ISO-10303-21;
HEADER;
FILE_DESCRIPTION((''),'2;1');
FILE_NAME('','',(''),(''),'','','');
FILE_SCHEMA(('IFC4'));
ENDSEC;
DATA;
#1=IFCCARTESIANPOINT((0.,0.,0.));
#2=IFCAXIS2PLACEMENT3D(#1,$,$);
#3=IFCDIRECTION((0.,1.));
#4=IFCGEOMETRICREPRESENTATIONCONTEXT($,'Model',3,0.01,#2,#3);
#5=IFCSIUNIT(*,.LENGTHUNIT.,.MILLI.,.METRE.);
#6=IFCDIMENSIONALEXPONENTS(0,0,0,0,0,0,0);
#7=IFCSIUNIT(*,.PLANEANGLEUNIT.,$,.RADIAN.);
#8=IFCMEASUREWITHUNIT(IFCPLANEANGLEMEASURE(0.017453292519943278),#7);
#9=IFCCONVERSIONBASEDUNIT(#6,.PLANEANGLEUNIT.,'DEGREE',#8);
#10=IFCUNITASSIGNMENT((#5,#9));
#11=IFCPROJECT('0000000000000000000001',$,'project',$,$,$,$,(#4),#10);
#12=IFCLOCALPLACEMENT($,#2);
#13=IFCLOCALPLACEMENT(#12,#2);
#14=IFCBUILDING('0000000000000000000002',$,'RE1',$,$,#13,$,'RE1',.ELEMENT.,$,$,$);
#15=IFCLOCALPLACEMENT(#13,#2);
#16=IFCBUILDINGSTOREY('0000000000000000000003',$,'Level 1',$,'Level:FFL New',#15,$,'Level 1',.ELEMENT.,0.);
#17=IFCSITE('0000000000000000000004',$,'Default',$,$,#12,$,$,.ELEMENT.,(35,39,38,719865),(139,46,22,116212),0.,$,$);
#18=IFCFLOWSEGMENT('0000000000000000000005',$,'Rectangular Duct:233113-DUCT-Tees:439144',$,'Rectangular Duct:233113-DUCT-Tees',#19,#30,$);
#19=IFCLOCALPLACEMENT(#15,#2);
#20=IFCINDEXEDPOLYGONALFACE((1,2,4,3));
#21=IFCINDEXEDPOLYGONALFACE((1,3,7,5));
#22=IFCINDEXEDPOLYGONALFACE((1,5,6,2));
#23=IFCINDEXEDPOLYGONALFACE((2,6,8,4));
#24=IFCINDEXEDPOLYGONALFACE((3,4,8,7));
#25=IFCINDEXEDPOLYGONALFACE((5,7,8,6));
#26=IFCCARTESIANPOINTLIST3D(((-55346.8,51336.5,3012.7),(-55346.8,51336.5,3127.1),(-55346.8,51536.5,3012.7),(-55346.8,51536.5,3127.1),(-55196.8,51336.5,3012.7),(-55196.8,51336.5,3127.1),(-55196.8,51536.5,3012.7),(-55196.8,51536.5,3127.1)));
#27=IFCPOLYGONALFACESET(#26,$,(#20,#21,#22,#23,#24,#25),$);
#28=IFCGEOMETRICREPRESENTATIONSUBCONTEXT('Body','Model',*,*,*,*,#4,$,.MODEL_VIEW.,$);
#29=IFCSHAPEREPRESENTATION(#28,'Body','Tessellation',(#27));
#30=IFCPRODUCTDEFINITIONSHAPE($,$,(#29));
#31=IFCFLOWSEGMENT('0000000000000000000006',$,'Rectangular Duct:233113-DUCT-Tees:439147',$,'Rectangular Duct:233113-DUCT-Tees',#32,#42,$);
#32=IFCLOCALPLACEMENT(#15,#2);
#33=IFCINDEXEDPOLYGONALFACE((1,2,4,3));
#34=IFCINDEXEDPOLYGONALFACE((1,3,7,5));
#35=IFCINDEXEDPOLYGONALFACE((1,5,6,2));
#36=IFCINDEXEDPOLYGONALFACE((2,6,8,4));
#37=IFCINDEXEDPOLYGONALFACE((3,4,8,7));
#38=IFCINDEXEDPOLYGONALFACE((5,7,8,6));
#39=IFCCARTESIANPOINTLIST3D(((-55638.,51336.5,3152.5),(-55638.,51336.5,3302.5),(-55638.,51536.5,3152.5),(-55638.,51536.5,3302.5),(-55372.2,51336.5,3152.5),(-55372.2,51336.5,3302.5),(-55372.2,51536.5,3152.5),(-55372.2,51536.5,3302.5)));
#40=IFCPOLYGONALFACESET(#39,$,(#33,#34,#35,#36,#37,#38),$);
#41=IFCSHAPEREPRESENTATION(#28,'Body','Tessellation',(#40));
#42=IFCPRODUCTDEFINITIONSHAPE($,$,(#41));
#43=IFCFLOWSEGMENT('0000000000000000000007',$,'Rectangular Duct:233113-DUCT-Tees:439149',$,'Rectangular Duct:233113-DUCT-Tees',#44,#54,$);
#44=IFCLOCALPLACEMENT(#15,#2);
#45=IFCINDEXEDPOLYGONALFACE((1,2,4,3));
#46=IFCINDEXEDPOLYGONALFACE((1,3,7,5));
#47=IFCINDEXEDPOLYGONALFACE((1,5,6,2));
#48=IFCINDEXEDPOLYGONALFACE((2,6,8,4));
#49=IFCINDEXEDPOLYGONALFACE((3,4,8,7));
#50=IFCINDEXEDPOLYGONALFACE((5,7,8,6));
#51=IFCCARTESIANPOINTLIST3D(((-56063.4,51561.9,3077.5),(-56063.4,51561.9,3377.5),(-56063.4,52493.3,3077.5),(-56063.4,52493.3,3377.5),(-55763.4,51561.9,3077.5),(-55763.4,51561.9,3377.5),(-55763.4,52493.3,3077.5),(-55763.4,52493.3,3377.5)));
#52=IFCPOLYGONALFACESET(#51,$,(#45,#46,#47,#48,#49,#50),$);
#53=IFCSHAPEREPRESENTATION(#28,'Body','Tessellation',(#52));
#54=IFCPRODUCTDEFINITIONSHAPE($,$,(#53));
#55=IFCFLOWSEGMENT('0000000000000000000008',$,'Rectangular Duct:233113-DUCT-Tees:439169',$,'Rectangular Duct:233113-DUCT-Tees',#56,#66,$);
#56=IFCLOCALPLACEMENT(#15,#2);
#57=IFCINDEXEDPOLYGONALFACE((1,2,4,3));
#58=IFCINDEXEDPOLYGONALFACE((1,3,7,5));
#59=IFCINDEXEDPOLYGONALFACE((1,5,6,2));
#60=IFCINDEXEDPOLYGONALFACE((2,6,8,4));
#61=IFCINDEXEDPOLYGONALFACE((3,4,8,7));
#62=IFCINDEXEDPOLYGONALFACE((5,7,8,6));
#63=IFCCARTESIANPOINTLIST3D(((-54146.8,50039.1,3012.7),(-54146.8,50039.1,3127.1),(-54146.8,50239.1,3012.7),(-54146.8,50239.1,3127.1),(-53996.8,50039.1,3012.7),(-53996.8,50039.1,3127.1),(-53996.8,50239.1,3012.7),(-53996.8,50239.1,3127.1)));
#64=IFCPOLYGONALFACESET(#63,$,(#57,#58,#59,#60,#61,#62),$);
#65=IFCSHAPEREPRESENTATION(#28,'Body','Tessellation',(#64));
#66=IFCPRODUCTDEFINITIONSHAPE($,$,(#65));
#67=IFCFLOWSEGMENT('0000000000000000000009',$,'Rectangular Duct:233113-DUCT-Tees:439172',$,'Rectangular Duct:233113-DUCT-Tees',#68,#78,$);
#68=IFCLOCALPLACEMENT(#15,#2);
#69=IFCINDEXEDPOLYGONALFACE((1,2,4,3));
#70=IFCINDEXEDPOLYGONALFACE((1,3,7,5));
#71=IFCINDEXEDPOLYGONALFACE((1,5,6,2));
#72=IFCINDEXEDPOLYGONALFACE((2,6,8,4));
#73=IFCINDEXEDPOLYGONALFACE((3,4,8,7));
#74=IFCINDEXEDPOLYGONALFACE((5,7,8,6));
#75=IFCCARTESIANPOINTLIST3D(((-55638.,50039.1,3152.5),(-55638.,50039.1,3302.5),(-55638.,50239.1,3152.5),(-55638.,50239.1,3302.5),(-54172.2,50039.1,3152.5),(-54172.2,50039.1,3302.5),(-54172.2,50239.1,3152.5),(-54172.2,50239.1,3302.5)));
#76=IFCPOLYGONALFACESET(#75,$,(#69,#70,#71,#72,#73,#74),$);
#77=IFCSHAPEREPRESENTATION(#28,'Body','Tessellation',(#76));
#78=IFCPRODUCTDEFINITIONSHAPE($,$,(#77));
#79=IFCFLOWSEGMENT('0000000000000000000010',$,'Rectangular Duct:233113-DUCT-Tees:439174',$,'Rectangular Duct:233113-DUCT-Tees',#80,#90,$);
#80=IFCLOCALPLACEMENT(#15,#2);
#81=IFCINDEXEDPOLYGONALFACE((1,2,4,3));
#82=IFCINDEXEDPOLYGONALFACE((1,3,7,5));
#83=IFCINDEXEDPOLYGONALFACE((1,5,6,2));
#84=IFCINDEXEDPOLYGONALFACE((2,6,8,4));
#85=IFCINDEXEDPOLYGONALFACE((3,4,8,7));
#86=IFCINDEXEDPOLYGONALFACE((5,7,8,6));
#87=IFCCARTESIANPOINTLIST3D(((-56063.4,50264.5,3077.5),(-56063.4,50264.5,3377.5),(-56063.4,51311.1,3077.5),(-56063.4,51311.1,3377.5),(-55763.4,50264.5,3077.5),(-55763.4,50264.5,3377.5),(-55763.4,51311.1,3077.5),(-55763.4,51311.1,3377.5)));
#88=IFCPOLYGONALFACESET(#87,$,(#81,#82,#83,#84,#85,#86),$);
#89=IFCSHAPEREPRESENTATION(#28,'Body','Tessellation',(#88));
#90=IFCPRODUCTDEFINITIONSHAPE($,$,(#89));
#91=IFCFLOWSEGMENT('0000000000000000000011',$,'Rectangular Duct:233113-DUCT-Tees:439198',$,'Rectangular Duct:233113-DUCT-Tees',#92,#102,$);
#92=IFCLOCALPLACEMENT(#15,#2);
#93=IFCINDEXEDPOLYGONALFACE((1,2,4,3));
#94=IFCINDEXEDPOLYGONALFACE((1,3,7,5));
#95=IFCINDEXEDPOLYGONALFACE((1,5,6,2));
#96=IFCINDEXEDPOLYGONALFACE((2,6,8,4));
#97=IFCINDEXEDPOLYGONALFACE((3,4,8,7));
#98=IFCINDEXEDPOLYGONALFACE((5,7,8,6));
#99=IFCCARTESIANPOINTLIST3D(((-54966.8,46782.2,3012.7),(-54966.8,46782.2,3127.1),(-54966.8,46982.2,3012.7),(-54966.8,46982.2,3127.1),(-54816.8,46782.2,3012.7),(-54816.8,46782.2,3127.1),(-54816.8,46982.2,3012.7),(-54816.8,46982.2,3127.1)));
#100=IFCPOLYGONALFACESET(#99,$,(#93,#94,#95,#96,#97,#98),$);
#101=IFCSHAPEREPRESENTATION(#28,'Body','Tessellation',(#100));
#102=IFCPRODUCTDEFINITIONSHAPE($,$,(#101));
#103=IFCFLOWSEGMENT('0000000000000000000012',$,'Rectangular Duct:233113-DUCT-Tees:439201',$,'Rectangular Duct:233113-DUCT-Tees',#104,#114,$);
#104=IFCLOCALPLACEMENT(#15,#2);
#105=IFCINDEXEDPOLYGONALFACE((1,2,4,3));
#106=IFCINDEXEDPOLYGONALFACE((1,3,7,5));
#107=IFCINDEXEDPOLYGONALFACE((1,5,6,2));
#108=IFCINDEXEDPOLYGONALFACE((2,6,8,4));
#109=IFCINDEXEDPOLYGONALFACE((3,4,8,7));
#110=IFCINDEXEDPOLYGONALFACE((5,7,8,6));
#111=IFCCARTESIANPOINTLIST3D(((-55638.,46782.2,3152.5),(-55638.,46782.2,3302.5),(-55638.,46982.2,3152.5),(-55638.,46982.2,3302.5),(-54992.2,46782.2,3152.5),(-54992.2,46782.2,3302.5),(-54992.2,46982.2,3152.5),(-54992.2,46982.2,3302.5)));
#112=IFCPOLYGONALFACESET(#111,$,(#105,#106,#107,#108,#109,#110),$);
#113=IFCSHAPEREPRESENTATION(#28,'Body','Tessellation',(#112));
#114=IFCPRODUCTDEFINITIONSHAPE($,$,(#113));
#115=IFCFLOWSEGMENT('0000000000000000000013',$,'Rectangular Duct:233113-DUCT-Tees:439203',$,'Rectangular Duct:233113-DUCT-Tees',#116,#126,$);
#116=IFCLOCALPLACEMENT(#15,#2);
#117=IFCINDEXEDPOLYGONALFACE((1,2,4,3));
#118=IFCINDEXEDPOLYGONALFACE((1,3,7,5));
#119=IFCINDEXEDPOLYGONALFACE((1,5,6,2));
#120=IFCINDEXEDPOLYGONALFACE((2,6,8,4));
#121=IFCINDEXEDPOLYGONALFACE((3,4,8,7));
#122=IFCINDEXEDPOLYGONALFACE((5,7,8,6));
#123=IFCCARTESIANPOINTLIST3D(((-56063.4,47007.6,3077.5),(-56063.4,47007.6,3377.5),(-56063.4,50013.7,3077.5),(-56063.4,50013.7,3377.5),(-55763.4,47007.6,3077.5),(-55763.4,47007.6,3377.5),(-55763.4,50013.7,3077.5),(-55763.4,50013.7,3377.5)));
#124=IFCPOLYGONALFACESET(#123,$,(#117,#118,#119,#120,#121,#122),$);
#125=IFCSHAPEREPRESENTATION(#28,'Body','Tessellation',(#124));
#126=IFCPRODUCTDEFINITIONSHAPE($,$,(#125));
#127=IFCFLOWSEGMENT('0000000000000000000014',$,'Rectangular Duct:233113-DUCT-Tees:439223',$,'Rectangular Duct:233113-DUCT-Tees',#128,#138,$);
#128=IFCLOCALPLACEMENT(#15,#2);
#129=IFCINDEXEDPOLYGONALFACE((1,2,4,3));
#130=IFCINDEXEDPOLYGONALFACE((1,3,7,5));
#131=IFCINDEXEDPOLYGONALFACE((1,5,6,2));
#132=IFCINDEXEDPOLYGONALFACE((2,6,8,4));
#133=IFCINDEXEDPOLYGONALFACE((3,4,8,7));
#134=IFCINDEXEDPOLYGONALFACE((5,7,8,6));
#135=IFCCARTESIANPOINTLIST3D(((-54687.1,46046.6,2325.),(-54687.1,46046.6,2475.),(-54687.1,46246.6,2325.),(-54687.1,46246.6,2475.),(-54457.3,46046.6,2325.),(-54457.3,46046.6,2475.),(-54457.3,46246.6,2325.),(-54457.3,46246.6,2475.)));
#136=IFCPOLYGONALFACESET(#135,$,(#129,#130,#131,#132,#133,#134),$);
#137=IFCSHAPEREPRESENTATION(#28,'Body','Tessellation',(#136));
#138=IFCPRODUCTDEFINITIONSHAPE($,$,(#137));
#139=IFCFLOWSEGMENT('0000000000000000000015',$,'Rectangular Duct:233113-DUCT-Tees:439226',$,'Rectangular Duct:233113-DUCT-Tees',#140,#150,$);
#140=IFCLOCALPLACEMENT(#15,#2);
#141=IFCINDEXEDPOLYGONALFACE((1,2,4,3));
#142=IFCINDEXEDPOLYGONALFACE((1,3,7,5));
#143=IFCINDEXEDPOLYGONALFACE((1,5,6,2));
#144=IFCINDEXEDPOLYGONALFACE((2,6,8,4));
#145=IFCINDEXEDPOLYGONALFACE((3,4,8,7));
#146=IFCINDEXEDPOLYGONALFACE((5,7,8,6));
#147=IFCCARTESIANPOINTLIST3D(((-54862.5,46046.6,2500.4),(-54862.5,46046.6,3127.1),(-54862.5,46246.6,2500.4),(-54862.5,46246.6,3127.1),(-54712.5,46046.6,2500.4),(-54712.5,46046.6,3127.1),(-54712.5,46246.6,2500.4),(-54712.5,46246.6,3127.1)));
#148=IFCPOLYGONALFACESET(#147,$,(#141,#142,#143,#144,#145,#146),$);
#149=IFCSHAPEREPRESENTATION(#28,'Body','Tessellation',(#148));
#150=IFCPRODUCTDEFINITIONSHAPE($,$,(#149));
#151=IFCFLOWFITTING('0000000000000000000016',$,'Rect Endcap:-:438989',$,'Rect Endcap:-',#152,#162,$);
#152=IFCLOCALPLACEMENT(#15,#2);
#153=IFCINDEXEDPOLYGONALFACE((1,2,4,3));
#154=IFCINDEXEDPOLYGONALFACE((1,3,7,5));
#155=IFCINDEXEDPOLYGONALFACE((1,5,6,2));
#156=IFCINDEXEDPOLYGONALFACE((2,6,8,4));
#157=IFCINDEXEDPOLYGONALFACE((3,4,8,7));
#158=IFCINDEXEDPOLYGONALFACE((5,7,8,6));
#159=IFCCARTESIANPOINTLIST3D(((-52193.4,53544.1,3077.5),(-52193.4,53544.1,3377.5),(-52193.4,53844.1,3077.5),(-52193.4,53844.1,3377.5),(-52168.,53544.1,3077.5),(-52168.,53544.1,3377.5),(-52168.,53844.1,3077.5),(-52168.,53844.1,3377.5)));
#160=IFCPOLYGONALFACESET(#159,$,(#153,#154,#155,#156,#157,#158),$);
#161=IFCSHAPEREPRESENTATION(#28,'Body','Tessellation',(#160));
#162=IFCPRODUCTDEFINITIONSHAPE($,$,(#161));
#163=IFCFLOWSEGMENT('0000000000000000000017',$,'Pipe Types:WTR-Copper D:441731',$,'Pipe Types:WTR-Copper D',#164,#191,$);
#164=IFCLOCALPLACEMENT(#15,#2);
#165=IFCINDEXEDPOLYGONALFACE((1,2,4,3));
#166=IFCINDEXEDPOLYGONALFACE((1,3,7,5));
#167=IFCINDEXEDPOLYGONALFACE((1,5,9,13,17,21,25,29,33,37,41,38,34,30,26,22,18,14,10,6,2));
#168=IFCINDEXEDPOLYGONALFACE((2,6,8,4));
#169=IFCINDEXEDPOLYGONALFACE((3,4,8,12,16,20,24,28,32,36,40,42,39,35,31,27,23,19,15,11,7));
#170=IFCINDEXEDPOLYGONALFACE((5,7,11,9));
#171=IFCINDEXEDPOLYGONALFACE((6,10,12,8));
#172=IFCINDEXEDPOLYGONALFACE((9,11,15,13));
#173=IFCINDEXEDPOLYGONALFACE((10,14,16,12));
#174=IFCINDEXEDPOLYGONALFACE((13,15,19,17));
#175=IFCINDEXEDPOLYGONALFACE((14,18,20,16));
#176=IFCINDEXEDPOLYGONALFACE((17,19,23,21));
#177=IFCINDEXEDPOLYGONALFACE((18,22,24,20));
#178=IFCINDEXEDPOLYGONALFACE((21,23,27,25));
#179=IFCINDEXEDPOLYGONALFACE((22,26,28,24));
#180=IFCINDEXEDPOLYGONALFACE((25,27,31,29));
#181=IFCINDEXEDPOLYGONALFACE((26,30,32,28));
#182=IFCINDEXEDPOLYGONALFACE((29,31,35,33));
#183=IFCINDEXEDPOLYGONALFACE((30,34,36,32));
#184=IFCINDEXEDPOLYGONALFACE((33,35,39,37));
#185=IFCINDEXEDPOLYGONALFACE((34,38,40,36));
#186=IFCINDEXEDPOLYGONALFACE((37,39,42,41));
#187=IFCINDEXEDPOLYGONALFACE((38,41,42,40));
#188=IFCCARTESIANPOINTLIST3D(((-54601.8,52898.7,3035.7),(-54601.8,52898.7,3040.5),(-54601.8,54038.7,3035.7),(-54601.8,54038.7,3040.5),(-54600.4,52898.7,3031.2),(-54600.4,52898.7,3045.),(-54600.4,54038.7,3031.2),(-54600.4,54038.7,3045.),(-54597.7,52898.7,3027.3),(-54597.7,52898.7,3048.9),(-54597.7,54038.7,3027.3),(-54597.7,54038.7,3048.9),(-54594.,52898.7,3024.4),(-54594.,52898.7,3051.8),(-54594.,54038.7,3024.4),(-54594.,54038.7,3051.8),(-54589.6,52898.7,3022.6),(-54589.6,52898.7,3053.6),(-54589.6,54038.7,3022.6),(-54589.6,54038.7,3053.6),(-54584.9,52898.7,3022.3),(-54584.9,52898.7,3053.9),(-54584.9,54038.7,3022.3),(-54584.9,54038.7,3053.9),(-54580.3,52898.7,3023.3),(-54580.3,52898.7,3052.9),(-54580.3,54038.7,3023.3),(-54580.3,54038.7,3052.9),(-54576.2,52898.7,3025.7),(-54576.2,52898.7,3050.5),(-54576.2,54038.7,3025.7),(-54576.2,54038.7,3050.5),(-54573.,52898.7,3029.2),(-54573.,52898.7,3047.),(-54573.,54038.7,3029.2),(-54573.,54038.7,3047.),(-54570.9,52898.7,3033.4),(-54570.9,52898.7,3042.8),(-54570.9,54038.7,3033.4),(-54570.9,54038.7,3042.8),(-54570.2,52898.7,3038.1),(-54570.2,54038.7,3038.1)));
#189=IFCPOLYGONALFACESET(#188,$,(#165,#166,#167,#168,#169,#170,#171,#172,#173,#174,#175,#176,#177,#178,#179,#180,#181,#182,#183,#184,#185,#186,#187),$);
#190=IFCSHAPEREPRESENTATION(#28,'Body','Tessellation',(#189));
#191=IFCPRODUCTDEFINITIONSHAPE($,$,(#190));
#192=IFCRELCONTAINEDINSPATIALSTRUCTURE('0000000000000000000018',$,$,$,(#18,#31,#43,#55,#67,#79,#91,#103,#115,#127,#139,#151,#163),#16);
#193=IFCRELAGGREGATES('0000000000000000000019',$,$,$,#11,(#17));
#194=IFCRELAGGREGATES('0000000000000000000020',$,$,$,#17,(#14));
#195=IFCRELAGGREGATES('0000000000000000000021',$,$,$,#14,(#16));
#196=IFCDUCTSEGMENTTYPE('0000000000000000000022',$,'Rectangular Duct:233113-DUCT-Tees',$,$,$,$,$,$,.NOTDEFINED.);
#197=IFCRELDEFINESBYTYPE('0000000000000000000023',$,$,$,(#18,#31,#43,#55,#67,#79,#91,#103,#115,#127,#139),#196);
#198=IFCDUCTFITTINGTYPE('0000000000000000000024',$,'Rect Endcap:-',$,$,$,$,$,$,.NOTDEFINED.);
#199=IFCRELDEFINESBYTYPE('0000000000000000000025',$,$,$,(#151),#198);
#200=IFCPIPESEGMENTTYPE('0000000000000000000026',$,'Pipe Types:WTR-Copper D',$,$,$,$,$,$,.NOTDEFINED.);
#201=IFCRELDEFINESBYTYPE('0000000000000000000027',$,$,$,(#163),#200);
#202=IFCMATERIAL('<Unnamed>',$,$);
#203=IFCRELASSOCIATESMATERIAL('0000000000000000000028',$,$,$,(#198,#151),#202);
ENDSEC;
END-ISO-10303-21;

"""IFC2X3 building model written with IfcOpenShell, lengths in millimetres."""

from ifc_helpers import new_model, entity, si_unit, converted_unit, direction, frame, frame_2d, origin, origin_2d_with_axis, place, context, subcontext, project, spatial, rectangle, circle, extrude, source, transform, mapped, material, type_object, type_shapes, element, save


model = new_model("IFC2X3")

# Units and contexts
model_context = context("Model", 3, precision=0.01, world=origin(), true_north=direction((0.0, 1.0)))
body_context = subcontext(model_context, "Body", "Model", "MODEL_VIEW")
ifc_project = project(units=[si_unit("LENGTHUNIT", "METRE", prefix="MILLI"), converted_unit("PLANEANGLEUNIT", "DEGREE", entity("IfcPlaneAngleMeasure", 0.017453292519943278), si_unit("PLANEANGLEUNIT", "RADIAN"), dimensions=[0, 0, 0, 0, 0, 0, 0])], contexts=[model_context])

# Site, building, storey
site_placement = place(None, origin())
site = spatial("IfcSite", under=ifc_project, at=site_placement, Name="Default", CompositionType="ELEMENT", RefLatitude=(35, 39, 38, 719865), RefLongitude=(139, 46, 22, 116212), RefElevation=0.0)
building_placement = place(site_placement, origin())
building = spatial("IfcBuilding", under=site, at=building_placement, Name="RE1", LongName="RE1", CompositionType="ELEMENT")
storey_placement = place(building_placement, origin())
storey = spatial("IfcBuildingStorey", under=building, at=storey_placement, Name="Level 1", ObjectType="Level:FFL New", LongName="Level 1", CompositionType="ELEMENT", Elevation=0.0)

# Flow segments
duct_segment_type = type_object("IfcDuctSegmentType", Name="Rectangular Duct:233113-DUCT-Tees", PredefinedType="NOTDEFINED")
flow_segment_1_placement = place(storey_placement, origin())
element("IfcFlowSegment", 1, at=flow_segment_1_placement, inside=storey, type_object=duct_segment_type, Name="Rectangular Duct:233113-DUCT-Tees:439144", ObjectType="Rectangular Duct:233113-DUCT-Tees", context=body_context, shape_type="SweptSolid", body=[
    extrude(rectangle(XDim=150.0, YDim=200.0, at=origin_2d_with_axis()), frame((-55271.8, 51436.5, 3012.7), z_axis=(0.0, 0.0, 1.0), x_axis=(-1.0, 0.0, 0.0)), (0.0, 0.0, 1.0), 114.4),
])
flow_segment_2_placement = place(storey_placement, origin())
element("IfcFlowSegment", 2, at=flow_segment_2_placement, inside=storey, type_object=duct_segment_type, Name="Rectangular Duct:233113-DUCT-Tees:439147", ObjectType="Rectangular Duct:233113-DUCT-Tees", context=body_context, shape_type="SweptSolid", body=[
    extrude(rectangle(XDim=265.9, YDim=200.0, at=frame_2d((0.0, 0.0), x_axis=(1.0, 0.0))), frame((-55505.1, 51436.5, 3152.5)), (0.0, 0.0, 1.0), 150.0),
])
flow_segment_3_placement = place(storey_placement, origin())
element("IfcFlowSegment", 3, at=flow_segment_3_placement, inside=storey, type_object=duct_segment_type, Name="Rectangular Duct:233113-DUCT-Tees:439149", ObjectType="Rectangular Duct:233113-DUCT-Tees", context=body_context, shape_type="SweptSolid", body=[
    extrude(rectangle(XDim=931.5, YDim=300.0, at=frame_2d((0.0, 0.0), x_axis=(1.0, 0.0))), frame((-55913.4, 52027.6, 3077.5), z_axis=(0.0, 0.0, 1.0), x_axis=(0.0, -1.0, 0.0)), (0.0, 0.0, 1.0), 300.0),
])
flow_segment_4_placement = place(storey_placement, origin())
element("IfcFlowSegment", 4, at=flow_segment_4_placement, inside=storey, type_object=duct_segment_type, Name="Rectangular Duct:233113-DUCT-Tees:439169", ObjectType="Rectangular Duct:233113-DUCT-Tees", context=body_context, shape_type="SweptSolid", body=[
    extrude(rectangle(XDim=150.0, YDim=200.0, at=origin_2d_with_axis()), frame((-54071.8, 50139.1, 3012.7), z_axis=(0.0, 0.0, 1.0), x_axis=(-1.0, 0.0, 0.0)), (0.0, 0.0, 1.0), 114.4),
])
flow_segment_5_placement = place(storey_placement, origin())
element("IfcFlowSegment", 5, at=flow_segment_5_placement, inside=storey, type_object=duct_segment_type, Name="Rectangular Duct:233113-DUCT-Tees:439172", ObjectType="Rectangular Duct:233113-DUCT-Tees", context=body_context, shape_type="SweptSolid", body=[
    extrude(rectangle(XDim=1465.9, YDim=200.0, at=frame_2d((0.0, 0.0), x_axis=(1.0, 0.0))), frame((-54905.1, 50139.1, 3152.5)), (0.0, 0.0, 1.0), 150.0),
])
flow_segment_6_placement = place(storey_placement, origin())
element("IfcFlowSegment", 6, at=flow_segment_6_placement, inside=storey, type_object=duct_segment_type, Name="Rectangular Duct:233113-DUCT-Tees:439174", ObjectType="Rectangular Duct:233113-DUCT-Tees", context=body_context, shape_type="SweptSolid", body=[
    extrude(rectangle(XDim=1046.5, YDim=300.0, at=frame_2d((0.0, 0.0), x_axis=(1.0, 0.0))), frame((-55913.4, 50787.8, 3077.5), z_axis=(0.0, 0.0, 1.0), x_axis=(0.0, -1.0, 0.0)), (0.0, 0.0, 1.0), 300.0),
])
flow_segment_7_placement = place(storey_placement, origin())
element("IfcFlowSegment", 7, at=flow_segment_7_placement, inside=storey, type_object=duct_segment_type, Name="Rectangular Duct:233113-DUCT-Tees:439198", ObjectType="Rectangular Duct:233113-DUCT-Tees", context=body_context, shape_type="SweptSolid", body=[
    extrude(rectangle(XDim=150.0, YDim=200.0, at=origin_2d_with_axis()), frame((-54891.8, 46882.2, 3012.7), z_axis=(0.0, 0.0, 1.0), x_axis=(-1.0, 0.0, 0.0)), (0.0, 0.0, 1.0), 114.4),
])
flow_segment_8_placement = place(storey_placement, origin())
element("IfcFlowSegment", 8, at=flow_segment_8_placement, inside=storey, type_object=duct_segment_type, Name="Rectangular Duct:233113-DUCT-Tees:439201", ObjectType="Rectangular Duct:233113-DUCT-Tees", context=body_context, shape_type="SweptSolid", body=[
    extrude(rectangle(XDim=645.9, YDim=200.0, at=frame_2d((0.0, 0.0), x_axis=(1.0, 0.0))), frame((-55315.1, 46882.2, 3152.5)), (0.0, 0.0, 1.0), 150.0),
])
flow_segment_9_placement = place(storey_placement, origin())
element("IfcFlowSegment", 9, at=flow_segment_9_placement, inside=storey, type_object=duct_segment_type, Name="Rectangular Duct:233113-DUCT-Tees:439203", ObjectType="Rectangular Duct:233113-DUCT-Tees", context=body_context, shape_type="SweptSolid", body=[
    extrude(rectangle(XDim=3006.1, YDim=300.0, at=frame_2d((0.0, 0.0), x_axis=(1.0, 0.0))), frame((-55913.4, 48510.7, 3077.5), z_axis=(0.0, 0.0, 1.0), x_axis=(0.0, -1.0, 0.0)), (0.0, 0.0, 1.0), 300.0),
])
flow_segment_10_placement = place(storey_placement, origin())
element("IfcFlowSegment", 10, at=flow_segment_10_placement, inside=storey, type_object=duct_segment_type, Name="Rectangular Duct:233113-DUCT-Tees:439223", ObjectType="Rectangular Duct:233113-DUCT-Tees", context=body_context, shape_type="SweptSolid", body=[
    extrude(rectangle(XDim=229.8, YDim=200.0, at=frame_2d((0.0, 0.0), x_axis=(1.0, 0.0))), frame((-54572.2, 46146.6, 2325.0), z_axis=(0.0, 0.0, 1.0), x_axis=(-1.0, 0.0, 0.0)), (0.0, 0.0, 1.0), 150.0),
])
flow_segment_11_placement = place(storey_placement, origin())
element("IfcFlowSegment", 11, at=flow_segment_11_placement, inside=storey, type_object=duct_segment_type, Name="Rectangular Duct:233113-DUCT-Tees:439226", ObjectType="Rectangular Duct:233113-DUCT-Tees", context=body_context, shape_type="SweptSolid", body=[
    extrude(rectangle(XDim=200.0, YDim=150.0, at=origin_2d_with_axis()), frame((-54787.5, 46146.6, 2500.4), z_axis=(0.0, 0.0, 1.0), x_axis=(0.0, -1.0, 0.0)), (0.0, 0.0, 1.0), 626.7),
])

# Flow fitting
ifc_material = material(Name="<Unnamed>")
duct_fitting_type_1 = type_object("IfcDuctFittingType", Name="Rect Endcap:-", PredefinedType="NOTDEFINED", material=ifc_material)
shared_shape_1 = source(origin(), body_context, "Body", "SweptSolid", [
    extrude(rectangle(XDim=25.4, YDim=300.0, at=frame_2d((0.0, 0.0), x_axis=(1.0, 0.0))), frame((12.7, 0.0, -150.0)), (0.0, 0.0, 1.0), 300.0),
])
type_shapes(duct_fitting_type_1, [shared_shape_1])
flow_fitting_1_placement = place(storey_placement, frame((-52193.4, 53694.1, 3227.5)))
element("IfcFlowFitting", 12, at=flow_fitting_1_placement, inside=storey, type_object=duct_fitting_type_1, material=ifc_material, Name="Rect Endcap:-:438989", ObjectType="Rect Endcap:-", context=body_context, shape_type="MappedRepresentation", body=[
    mapped(shared_shape_1, transform((0.0, 0.0, 0.0), scale=1.0)),
])

# Flow segment
pipe_segment_type_1 = type_object("IfcPipeSegmentType", Name="Pipe Types:WTR-Copper D", PredefinedType="NOTDEFINED")
flow_segment_12_placement = place(storey_placement, origin())
element("IfcFlowSegment", 13, at=flow_segment_12_placement, inside=storey, type_object=pipe_segment_type_1, Name="Pipe Types:WTR-Copper D:441731", ObjectType="Pipe Types:WTR-Copper D", context=body_context, shape_type="SweptSolid", body=[
    extrude(circle(Radius=15.9, at=origin_2d_with_axis()), frame((-54586.1, 52898.7, 3038.1), z_axis=(0.0, 1.0, 0.0), x_axis=(1.0, 0.0, 0.0)), (0.0, 0.0, 1.0), 1140.0),
])

save(model, "model.ifc")
